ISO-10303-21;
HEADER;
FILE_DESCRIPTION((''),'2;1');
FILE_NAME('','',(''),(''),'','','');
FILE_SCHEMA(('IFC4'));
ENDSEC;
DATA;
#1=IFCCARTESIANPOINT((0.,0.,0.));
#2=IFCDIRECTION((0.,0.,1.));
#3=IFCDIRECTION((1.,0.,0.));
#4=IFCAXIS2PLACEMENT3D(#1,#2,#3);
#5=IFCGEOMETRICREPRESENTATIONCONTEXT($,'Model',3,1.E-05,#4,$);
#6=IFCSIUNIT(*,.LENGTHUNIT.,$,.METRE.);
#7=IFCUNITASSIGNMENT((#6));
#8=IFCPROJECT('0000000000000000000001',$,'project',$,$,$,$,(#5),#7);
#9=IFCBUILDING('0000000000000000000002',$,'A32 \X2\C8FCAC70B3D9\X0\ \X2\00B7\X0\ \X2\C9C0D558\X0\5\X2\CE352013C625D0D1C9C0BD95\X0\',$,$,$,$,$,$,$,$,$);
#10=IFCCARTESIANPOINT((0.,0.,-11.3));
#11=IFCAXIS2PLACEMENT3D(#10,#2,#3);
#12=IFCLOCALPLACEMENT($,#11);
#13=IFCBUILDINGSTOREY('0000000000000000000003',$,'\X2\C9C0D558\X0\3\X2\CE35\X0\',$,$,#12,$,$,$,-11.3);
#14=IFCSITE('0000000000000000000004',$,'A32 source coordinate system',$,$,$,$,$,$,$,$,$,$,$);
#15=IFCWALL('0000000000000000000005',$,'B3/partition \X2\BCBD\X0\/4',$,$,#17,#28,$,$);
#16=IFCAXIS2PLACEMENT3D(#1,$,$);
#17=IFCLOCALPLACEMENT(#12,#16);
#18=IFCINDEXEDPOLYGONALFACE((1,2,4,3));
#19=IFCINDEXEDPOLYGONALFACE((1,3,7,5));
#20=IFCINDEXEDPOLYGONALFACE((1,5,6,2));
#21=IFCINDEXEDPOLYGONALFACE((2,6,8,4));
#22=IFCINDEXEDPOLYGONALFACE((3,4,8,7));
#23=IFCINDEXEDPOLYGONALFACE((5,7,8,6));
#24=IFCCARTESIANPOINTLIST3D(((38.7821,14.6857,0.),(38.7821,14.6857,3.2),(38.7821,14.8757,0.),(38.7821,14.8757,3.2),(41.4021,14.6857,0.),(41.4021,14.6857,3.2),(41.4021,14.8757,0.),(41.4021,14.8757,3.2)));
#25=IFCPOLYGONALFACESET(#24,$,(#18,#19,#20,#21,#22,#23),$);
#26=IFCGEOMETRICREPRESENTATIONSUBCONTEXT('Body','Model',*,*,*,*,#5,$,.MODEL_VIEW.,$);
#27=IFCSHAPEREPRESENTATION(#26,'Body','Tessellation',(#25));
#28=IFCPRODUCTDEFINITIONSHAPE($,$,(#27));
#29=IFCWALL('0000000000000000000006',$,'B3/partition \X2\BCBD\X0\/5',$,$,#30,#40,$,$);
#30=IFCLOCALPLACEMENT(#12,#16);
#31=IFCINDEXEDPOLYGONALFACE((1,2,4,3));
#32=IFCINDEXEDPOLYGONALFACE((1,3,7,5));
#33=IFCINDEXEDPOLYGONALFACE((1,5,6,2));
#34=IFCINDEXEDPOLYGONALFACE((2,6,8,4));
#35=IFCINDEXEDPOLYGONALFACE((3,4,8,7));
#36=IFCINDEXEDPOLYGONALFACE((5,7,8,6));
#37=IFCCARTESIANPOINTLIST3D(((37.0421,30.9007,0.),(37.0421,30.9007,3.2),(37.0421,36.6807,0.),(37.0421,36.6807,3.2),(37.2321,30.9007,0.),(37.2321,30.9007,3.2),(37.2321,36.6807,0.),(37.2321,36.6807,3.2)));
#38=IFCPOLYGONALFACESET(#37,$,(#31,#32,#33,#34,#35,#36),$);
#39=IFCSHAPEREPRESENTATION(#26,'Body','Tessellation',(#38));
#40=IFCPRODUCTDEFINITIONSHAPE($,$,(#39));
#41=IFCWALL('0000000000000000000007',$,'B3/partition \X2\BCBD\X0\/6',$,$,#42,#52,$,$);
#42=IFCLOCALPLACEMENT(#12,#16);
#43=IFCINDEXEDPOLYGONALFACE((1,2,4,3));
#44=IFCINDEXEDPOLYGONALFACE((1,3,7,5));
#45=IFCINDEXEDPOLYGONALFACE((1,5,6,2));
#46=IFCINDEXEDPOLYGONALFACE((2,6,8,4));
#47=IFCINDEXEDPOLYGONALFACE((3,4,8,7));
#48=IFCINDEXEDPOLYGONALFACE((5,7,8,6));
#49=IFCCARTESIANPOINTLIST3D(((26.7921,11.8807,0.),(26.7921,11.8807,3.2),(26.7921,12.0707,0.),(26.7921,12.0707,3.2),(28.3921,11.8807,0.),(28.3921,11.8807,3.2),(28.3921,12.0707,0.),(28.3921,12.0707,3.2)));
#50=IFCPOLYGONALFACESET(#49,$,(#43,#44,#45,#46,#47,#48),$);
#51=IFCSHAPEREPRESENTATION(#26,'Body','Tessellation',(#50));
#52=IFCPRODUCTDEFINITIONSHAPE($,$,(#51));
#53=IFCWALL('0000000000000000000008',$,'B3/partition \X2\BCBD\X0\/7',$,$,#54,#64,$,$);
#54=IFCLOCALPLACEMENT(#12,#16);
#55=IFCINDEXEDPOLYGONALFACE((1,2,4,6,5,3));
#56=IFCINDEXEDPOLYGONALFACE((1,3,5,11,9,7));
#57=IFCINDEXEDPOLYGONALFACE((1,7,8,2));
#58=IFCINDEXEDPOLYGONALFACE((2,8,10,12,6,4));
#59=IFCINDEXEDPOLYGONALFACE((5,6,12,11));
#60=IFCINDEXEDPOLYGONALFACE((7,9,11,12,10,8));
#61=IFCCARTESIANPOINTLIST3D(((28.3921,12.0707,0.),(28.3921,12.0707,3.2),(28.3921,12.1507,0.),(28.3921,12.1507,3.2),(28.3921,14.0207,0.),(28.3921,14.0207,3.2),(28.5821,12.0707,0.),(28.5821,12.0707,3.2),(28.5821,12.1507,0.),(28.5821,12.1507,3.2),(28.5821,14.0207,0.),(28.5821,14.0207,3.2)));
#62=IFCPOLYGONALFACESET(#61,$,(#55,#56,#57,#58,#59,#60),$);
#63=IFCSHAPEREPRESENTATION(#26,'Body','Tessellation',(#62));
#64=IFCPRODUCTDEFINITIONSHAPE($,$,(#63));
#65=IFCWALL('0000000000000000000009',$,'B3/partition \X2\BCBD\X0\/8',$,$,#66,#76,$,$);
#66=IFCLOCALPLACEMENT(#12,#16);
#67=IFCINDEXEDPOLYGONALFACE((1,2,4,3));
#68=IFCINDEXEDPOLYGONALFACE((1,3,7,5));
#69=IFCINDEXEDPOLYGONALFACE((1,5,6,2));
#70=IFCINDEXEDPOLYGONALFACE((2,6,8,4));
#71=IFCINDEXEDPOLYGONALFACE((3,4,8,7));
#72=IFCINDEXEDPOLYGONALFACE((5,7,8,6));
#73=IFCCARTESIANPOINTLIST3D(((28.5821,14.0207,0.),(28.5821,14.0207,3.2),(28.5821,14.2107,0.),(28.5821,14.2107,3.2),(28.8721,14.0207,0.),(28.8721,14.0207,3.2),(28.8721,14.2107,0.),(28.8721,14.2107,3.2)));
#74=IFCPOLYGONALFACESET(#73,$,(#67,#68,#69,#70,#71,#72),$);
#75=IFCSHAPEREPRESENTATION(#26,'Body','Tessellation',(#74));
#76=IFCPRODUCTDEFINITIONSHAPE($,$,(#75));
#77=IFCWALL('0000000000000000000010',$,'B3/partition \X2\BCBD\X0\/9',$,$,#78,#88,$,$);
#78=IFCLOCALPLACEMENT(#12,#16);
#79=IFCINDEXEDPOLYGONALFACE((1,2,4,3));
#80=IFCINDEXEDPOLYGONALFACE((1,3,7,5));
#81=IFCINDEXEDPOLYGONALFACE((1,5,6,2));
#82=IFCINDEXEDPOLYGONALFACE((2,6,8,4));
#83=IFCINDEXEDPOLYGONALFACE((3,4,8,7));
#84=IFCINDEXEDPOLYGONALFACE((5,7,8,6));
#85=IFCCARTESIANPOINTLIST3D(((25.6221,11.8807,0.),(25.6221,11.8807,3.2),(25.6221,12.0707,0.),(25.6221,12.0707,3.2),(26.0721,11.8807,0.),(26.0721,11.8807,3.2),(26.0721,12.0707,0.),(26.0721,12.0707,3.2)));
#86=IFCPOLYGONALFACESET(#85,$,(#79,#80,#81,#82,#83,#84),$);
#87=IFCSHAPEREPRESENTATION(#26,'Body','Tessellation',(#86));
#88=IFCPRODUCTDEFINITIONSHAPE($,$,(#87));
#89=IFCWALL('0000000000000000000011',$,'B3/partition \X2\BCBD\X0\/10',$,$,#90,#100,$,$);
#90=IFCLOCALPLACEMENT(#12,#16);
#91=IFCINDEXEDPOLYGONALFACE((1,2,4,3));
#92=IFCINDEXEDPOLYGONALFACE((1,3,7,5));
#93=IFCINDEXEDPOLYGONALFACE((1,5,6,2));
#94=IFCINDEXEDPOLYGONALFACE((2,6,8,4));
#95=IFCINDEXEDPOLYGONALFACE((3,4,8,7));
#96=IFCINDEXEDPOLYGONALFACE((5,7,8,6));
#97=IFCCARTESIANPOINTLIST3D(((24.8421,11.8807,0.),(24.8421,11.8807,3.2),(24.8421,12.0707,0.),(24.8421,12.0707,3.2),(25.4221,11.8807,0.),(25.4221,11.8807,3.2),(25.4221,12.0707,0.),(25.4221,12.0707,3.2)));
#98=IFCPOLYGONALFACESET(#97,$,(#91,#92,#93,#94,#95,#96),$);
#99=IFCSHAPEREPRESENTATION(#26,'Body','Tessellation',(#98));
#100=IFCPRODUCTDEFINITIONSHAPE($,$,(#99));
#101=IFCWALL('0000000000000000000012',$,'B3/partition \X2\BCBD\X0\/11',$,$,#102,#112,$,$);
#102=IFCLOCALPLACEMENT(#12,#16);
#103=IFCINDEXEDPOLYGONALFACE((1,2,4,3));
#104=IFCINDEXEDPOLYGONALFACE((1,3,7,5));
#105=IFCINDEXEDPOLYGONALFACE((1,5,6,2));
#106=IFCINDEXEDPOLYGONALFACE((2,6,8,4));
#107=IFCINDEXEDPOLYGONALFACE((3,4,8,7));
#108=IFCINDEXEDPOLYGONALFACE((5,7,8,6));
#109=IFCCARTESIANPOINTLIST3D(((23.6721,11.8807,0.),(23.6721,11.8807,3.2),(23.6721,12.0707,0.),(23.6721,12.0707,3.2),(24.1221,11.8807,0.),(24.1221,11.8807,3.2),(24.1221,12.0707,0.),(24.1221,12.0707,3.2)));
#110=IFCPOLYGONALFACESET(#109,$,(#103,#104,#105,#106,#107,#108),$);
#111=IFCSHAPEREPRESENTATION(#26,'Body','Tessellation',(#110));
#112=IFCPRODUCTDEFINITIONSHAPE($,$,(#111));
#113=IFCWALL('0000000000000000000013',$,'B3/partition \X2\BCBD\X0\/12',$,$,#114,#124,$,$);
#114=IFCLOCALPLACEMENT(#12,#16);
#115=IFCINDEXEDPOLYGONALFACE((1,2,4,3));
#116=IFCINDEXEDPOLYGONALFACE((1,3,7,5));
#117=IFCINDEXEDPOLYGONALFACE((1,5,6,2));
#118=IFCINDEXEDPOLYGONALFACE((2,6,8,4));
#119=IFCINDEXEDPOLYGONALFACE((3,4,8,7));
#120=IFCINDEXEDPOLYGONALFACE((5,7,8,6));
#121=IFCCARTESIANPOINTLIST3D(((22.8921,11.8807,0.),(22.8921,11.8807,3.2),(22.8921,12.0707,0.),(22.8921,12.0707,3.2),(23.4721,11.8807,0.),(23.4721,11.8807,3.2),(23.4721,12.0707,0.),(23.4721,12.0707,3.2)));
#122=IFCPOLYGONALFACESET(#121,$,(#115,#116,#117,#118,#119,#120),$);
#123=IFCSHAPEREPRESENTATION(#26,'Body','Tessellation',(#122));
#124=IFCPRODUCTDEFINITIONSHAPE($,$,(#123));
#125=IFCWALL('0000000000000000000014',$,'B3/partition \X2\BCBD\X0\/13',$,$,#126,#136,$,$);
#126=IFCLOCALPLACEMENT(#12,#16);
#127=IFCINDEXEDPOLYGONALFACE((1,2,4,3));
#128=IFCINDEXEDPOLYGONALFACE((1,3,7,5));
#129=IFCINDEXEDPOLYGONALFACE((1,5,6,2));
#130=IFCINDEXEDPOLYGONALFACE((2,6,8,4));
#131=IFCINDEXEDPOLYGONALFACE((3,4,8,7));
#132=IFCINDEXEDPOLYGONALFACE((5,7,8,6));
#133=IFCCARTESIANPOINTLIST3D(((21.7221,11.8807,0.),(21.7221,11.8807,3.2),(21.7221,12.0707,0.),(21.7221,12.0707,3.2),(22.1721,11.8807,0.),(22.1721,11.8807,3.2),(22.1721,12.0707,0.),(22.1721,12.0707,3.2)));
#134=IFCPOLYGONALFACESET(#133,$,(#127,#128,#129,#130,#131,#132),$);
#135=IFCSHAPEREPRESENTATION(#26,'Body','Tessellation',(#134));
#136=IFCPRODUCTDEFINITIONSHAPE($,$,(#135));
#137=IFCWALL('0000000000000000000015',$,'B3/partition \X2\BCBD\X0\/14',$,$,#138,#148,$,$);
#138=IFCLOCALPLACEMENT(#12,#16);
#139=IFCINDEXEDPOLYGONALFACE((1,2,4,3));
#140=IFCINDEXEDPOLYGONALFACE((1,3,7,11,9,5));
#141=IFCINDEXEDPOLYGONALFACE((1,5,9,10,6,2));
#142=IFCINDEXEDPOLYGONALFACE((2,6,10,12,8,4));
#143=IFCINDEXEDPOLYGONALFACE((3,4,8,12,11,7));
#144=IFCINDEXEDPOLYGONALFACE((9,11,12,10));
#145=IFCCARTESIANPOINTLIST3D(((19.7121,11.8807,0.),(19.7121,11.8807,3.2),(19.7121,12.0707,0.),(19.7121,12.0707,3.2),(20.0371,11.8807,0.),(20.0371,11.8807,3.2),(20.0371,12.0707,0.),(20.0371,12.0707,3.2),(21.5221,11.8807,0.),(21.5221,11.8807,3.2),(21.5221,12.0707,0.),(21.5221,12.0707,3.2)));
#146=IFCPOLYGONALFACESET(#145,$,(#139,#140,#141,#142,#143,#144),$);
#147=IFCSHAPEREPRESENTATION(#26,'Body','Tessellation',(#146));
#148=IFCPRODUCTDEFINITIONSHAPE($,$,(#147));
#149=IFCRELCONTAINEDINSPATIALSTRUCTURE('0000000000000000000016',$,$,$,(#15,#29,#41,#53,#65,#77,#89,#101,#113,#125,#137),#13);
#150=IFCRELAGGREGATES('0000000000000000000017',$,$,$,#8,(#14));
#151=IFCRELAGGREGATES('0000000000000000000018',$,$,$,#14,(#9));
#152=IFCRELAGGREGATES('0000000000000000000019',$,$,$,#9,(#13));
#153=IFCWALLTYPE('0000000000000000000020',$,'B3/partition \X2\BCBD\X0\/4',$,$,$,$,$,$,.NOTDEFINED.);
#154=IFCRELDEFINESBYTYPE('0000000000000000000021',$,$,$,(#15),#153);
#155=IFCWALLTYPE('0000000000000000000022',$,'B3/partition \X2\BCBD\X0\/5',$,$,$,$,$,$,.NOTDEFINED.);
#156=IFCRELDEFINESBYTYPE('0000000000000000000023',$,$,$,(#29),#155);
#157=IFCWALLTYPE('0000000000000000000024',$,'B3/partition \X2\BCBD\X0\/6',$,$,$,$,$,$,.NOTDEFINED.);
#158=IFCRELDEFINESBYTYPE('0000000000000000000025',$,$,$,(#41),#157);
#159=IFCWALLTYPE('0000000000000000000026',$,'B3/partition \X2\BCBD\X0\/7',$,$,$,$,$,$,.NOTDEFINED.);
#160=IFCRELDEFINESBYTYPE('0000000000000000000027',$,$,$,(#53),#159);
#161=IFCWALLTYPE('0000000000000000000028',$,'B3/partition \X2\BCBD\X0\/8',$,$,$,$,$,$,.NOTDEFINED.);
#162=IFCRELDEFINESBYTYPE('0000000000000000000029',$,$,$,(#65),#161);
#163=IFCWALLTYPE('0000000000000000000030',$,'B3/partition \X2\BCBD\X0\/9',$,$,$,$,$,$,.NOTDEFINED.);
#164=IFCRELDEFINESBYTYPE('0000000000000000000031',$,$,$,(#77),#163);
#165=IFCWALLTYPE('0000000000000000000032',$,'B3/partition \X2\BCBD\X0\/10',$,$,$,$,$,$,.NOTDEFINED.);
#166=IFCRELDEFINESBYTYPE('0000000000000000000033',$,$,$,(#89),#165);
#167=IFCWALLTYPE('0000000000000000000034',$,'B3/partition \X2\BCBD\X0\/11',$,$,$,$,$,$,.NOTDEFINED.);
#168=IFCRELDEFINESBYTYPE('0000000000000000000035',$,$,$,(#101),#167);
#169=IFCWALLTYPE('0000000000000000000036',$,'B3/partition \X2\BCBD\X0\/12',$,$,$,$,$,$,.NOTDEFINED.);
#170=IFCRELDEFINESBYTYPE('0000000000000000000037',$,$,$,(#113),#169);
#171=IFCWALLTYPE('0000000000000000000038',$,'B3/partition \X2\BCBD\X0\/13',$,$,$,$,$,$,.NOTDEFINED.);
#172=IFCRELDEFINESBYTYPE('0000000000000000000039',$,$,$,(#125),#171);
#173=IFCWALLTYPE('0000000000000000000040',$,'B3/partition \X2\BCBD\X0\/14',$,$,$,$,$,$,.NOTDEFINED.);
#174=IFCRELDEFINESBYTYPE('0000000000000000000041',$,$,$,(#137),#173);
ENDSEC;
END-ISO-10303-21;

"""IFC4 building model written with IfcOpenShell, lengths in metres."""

from ifc_helpers import new_model, si_unit, frame, origin, origin_with_axes, place, context, subcontext, project, spatial, polyline, outline, extrude, source, transform, mapped, type_object, type_shapes, element, save


model = new_model("IFC4")

# Units and contexts
model_context = context("Model", 3, precision=1e-05, world=origin_with_axes())
body_context = subcontext(model_context, "Body", "Model", "MODEL_VIEW")
ifc_project = project(units=[si_unit("LENGTHUNIT", "METRE")], contexts=[model_context])

# Site, building, storey
site = spatial("IfcSite", under=ifc_project, Name="A32 source coordinate system")
building = spatial("IfcBuilding", under=site, Name="A32 주거동 · 지하5층–옥탑지붕")
storey_placement = place(None, frame((0.0, 0.0, -11.3), z_axis=(0.0, 0.0, 1.0), x_axis=(1.0, 0.0, 0.0)))
storey = spatial("IfcBuildingStorey", under=building, at=storey_placement, Name="지하3층", Elevation=-11.3)

# Walls
wall_type_1 = type_object("IfcWallType", Name="B3/partition 벽/4", PredefinedType="NOTDEFINED")
shared_shape_1 = source(origin(), body_context, "Body", "SweptSolid", [
    extrude(outline(polyline([(38.7821, 14.8757), (41.4021, 14.8757), (41.4021, 14.6857), (38.7821, 14.6857), (38.7821, 14.8757)])), origin(), (0.0, 0.0, 1.0), 3.2),
])
type_shapes(wall_type_1, [shared_shape_1])
wall_1_placement = place(storey_placement, origin_with_axes())
element("IfcWall", 1, at=wall_1_placement, inside=storey, type_object=wall_type_1, Name="B3/partition 벽/4", context=body_context, shape_type="MappedRepresentation", body=[
    mapped(shared_shape_1, transform((0.0, 0.0, 0.0), scale=1.0)),
])
wall_type_2 = type_object("IfcWallType", Name="B3/partition 벽/5", PredefinedType="NOTDEFINED")
shared_shape_2 = source(origin(), body_context, "Body", "SweptSolid", [
    extrude(outline(polyline([(37.2321, 36.6807), (37.2321, 30.9007), (37.0421, 30.9007), (37.0421, 36.6807), (37.2321, 36.6807)])), origin(), (0.0, 0.0, 1.0), 3.2),
])
type_shapes(wall_type_2, [shared_shape_2])
wall_2_placement = place(storey_placement, origin_with_axes())
element("IfcWall", 2, at=wall_2_placement, inside=storey, type_object=wall_type_2, Name="B3/partition 벽/5", context=body_context, shape_type="MappedRepresentation", body=[
    mapped(shared_shape_2, transform((0.0, 0.0, 0.0), scale=1.0)),
])
wall_type_3 = type_object("IfcWallType", Name="B3/partition 벽/6", PredefinedType="NOTDEFINED")
shared_shape_3 = source(origin(), body_context, "Body", "SweptSolid", [
    extrude(outline(polyline([(26.7921, 11.8807), (26.7921, 12.0707), (28.3921, 12.0707), (28.3921, 11.8807), (26.7921, 11.8807)])), origin(), (0.0, 0.0, 1.0), 3.2),
])
type_shapes(wall_type_3, [shared_shape_3])
wall_3_placement = place(storey_placement, origin_with_axes())
element("IfcWall", 3, at=wall_3_placement, inside=storey, type_object=wall_type_3, Name="B3/partition 벽/6", context=body_context, shape_type="MappedRepresentation", body=[
    mapped(shared_shape_3, transform((0.0, 0.0, 0.0), scale=1.0)),
])
wall_type_4 = type_object("IfcWallType", Name="B3/partition 벽/7", PredefinedType="NOTDEFINED")
shared_shape_4 = source(origin(), body_context, "Body", "SweptSolid", [
    extrude(outline(polyline([(28.3921, 12.1507), (28.3921, 14.0207), (28.5821, 14.0207), (28.5821, 12.1507), (28.5821, 12.0707), (28.3921, 12.0707), (28.3921, 12.1507)])), origin(), (0.0, 0.0, 1.0), 3.2),
])
type_shapes(wall_type_4, [shared_shape_4])
wall_4_placement = place(storey_placement, origin_with_axes())
element("IfcWall", 4, at=wall_4_placement, inside=storey, type_object=wall_type_4, Name="B3/partition 벽/7", context=body_context, shape_type="MappedRepresentation", body=[
    mapped(shared_shape_4, transform((0.0, 0.0, 0.0), scale=1.0)),
])
wall_type_5 = type_object("IfcWallType", Name="B3/partition 벽/8", PredefinedType="NOTDEFINED")
shared_shape_5 = source(origin(), body_context, "Body", "SweptSolid", [
    extrude(outline(polyline([(28.5821, 14.2107), (28.8721, 14.2107), (28.8721, 14.0207), (28.5821, 14.0207), (28.5821, 14.2107)])), origin(), (0.0, 0.0, 1.0), 3.2),
])
type_shapes(wall_type_5, [shared_shape_5])
wall_5_placement = place(storey_placement, origin_with_axes())
element("IfcWall", 5, at=wall_5_placement, inside=storey, type_object=wall_type_5, Name="B3/partition 벽/8", context=body_context, shape_type="MappedRepresentation", body=[
    mapped(shared_shape_5, transform((0.0, 0.0, 0.0), scale=1.0)),
])
wall_type_6 = type_object("IfcWallType", Name="B3/partition 벽/9", PredefinedType="NOTDEFINED")
shared_shape_6 = source(origin(), body_context, "Body", "SweptSolid", [
    extrude(outline(polyline([(26.0721, 12.0707), (26.0721, 11.8807), (25.6221, 11.8807), (25.6221, 12.0707), (26.0721, 12.0707)])), origin(), (0.0, 0.0, 1.0), 3.2),
])
type_shapes(wall_type_6, [shared_shape_6])
wall_6_placement = place(storey_placement, origin_with_axes())
element("IfcWall", 6, at=wall_6_placement, inside=storey, type_object=wall_type_6, Name="B3/partition 벽/9", context=body_context, shape_type="MappedRepresentation", body=[
    mapped(shared_shape_6, transform((0.0, 0.0, 0.0), scale=1.0)),
])
wall_type_7 = type_object("IfcWallType", Name="B3/partition 벽/10", PredefinedType="NOTDEFINED")
shared_shape_7 = source(origin(), body_context, "Body", "SweptSolid", [
    extrude(outline(polyline([(25.4221, 12.0707), (25.4221, 11.8807), (24.8421, 11.8807), (24.8421, 12.0707), (25.4221, 12.0707)])), origin(), (0.0, 0.0, 1.0), 3.2),
])
type_shapes(wall_type_7, [shared_shape_7])
wall_7_placement = place(storey_placement, origin_with_axes())
element("IfcWall", 7, at=wall_7_placement, inside=storey, type_object=wall_type_7, Name="B3/partition 벽/10", context=body_context, shape_type="MappedRepresentation", body=[
    mapped(shared_shape_7, transform((0.0, 0.0, 0.0), scale=1.0)),
])
wall_type_8 = type_object("IfcWallType", Name="B3/partition 벽/11", PredefinedType="NOTDEFINED")
shared_shape_8 = source(origin(), body_context, "Body", "SweptSolid", [
    extrude(outline(polyline([(23.6721, 12.0707), (24.1221, 12.0707), (24.1221, 11.8807), (23.6721, 11.8807), (23.6721, 12.0707)])), origin(), (0.0, 0.0, 1.0), 3.2),
])
type_shapes(wall_type_8, [shared_shape_8])
wall_8_placement = place(storey_placement, origin_with_axes())
element("IfcWall", 8, at=wall_8_placement, inside=storey, type_object=wall_type_8, Name="B3/partition 벽/11", context=body_context, shape_type="MappedRepresentation", body=[
    mapped(shared_shape_8, transform((0.0, 0.0, 0.0), scale=1.0)),
])
wall_type_9 = type_object("IfcWallType", Name="B3/partition 벽/12", PredefinedType="NOTDEFINED")
shared_shape_9 = source(origin(), body_context, "Body", "SweptSolid", [
    extrude(outline(polyline([(23.4721, 12.0707), (23.4721, 11.8807), (22.8921, 11.8807), (22.8921, 12.0707), (23.4721, 12.0707)])), origin(), (0.0, 0.0, 1.0), 3.2),
])
type_shapes(wall_type_9, [shared_shape_9])
wall_9_placement = place(storey_placement, origin_with_axes())
element("IfcWall", 9, at=wall_9_placement, inside=storey, type_object=wall_type_9, Name="B3/partition 벽/12", context=body_context, shape_type="MappedRepresentation", body=[
    mapped(shared_shape_9, transform((0.0, 0.0, 0.0), scale=1.0)),
])
wall_type_10 = type_object("IfcWallType", Name="B3/partition 벽/13", PredefinedType="NOTDEFINED")
shared_shape_10 = source(origin(), body_context, "Body", "SweptSolid", [
    extrude(outline(polyline([(22.1721, 12.0707), (22.1721, 11.8807), (21.7221, 11.8807), (21.7221, 12.0707), (22.1721, 12.0707)])), origin(), (0.0, 0.0, 1.0), 3.2),
])
type_shapes(wall_type_10, [shared_shape_10])
wall_10_placement = place(storey_placement, origin_with_axes())
element("IfcWall", 10, at=wall_10_placement, inside=storey, type_object=wall_type_10, Name="B3/partition 벽/13", context=body_context, shape_type="MappedRepresentation", body=[
    mapped(shared_shape_10, transform((0.0, 0.0, 0.0), scale=1.0)),
])
wall_type_11 = type_object("IfcWallType", Name="B3/partition 벽/14", PredefinedType="NOTDEFINED")
shared_shape_11 = source(origin(), body_context, "Body", "SweptSolid", [
    extrude(outline(polyline([(19.7121, 11.8807), (19.7121, 12.0707), (20.0371, 12.0707), (21.5221, 12.0707), (21.5221, 11.8807), (20.0371, 11.8807), (19.7121, 11.8807)])), origin(), (0.0, 0.0, 1.0), 3.2),
])
type_shapes(wall_type_11, [shared_shape_11])
wall_11_placement = place(storey_placement, origin_with_axes())
element("IfcWall", 11, at=wall_11_placement, inside=storey, type_object=wall_type_11, Name="B3/partition 벽/14", context=body_context, shape_type="MappedRepresentation", body=[
    mapped(shared_shape_11, transform((0.0, 0.0, 0.0), scale=1.0)),
])

save(model, "model.ifc")
